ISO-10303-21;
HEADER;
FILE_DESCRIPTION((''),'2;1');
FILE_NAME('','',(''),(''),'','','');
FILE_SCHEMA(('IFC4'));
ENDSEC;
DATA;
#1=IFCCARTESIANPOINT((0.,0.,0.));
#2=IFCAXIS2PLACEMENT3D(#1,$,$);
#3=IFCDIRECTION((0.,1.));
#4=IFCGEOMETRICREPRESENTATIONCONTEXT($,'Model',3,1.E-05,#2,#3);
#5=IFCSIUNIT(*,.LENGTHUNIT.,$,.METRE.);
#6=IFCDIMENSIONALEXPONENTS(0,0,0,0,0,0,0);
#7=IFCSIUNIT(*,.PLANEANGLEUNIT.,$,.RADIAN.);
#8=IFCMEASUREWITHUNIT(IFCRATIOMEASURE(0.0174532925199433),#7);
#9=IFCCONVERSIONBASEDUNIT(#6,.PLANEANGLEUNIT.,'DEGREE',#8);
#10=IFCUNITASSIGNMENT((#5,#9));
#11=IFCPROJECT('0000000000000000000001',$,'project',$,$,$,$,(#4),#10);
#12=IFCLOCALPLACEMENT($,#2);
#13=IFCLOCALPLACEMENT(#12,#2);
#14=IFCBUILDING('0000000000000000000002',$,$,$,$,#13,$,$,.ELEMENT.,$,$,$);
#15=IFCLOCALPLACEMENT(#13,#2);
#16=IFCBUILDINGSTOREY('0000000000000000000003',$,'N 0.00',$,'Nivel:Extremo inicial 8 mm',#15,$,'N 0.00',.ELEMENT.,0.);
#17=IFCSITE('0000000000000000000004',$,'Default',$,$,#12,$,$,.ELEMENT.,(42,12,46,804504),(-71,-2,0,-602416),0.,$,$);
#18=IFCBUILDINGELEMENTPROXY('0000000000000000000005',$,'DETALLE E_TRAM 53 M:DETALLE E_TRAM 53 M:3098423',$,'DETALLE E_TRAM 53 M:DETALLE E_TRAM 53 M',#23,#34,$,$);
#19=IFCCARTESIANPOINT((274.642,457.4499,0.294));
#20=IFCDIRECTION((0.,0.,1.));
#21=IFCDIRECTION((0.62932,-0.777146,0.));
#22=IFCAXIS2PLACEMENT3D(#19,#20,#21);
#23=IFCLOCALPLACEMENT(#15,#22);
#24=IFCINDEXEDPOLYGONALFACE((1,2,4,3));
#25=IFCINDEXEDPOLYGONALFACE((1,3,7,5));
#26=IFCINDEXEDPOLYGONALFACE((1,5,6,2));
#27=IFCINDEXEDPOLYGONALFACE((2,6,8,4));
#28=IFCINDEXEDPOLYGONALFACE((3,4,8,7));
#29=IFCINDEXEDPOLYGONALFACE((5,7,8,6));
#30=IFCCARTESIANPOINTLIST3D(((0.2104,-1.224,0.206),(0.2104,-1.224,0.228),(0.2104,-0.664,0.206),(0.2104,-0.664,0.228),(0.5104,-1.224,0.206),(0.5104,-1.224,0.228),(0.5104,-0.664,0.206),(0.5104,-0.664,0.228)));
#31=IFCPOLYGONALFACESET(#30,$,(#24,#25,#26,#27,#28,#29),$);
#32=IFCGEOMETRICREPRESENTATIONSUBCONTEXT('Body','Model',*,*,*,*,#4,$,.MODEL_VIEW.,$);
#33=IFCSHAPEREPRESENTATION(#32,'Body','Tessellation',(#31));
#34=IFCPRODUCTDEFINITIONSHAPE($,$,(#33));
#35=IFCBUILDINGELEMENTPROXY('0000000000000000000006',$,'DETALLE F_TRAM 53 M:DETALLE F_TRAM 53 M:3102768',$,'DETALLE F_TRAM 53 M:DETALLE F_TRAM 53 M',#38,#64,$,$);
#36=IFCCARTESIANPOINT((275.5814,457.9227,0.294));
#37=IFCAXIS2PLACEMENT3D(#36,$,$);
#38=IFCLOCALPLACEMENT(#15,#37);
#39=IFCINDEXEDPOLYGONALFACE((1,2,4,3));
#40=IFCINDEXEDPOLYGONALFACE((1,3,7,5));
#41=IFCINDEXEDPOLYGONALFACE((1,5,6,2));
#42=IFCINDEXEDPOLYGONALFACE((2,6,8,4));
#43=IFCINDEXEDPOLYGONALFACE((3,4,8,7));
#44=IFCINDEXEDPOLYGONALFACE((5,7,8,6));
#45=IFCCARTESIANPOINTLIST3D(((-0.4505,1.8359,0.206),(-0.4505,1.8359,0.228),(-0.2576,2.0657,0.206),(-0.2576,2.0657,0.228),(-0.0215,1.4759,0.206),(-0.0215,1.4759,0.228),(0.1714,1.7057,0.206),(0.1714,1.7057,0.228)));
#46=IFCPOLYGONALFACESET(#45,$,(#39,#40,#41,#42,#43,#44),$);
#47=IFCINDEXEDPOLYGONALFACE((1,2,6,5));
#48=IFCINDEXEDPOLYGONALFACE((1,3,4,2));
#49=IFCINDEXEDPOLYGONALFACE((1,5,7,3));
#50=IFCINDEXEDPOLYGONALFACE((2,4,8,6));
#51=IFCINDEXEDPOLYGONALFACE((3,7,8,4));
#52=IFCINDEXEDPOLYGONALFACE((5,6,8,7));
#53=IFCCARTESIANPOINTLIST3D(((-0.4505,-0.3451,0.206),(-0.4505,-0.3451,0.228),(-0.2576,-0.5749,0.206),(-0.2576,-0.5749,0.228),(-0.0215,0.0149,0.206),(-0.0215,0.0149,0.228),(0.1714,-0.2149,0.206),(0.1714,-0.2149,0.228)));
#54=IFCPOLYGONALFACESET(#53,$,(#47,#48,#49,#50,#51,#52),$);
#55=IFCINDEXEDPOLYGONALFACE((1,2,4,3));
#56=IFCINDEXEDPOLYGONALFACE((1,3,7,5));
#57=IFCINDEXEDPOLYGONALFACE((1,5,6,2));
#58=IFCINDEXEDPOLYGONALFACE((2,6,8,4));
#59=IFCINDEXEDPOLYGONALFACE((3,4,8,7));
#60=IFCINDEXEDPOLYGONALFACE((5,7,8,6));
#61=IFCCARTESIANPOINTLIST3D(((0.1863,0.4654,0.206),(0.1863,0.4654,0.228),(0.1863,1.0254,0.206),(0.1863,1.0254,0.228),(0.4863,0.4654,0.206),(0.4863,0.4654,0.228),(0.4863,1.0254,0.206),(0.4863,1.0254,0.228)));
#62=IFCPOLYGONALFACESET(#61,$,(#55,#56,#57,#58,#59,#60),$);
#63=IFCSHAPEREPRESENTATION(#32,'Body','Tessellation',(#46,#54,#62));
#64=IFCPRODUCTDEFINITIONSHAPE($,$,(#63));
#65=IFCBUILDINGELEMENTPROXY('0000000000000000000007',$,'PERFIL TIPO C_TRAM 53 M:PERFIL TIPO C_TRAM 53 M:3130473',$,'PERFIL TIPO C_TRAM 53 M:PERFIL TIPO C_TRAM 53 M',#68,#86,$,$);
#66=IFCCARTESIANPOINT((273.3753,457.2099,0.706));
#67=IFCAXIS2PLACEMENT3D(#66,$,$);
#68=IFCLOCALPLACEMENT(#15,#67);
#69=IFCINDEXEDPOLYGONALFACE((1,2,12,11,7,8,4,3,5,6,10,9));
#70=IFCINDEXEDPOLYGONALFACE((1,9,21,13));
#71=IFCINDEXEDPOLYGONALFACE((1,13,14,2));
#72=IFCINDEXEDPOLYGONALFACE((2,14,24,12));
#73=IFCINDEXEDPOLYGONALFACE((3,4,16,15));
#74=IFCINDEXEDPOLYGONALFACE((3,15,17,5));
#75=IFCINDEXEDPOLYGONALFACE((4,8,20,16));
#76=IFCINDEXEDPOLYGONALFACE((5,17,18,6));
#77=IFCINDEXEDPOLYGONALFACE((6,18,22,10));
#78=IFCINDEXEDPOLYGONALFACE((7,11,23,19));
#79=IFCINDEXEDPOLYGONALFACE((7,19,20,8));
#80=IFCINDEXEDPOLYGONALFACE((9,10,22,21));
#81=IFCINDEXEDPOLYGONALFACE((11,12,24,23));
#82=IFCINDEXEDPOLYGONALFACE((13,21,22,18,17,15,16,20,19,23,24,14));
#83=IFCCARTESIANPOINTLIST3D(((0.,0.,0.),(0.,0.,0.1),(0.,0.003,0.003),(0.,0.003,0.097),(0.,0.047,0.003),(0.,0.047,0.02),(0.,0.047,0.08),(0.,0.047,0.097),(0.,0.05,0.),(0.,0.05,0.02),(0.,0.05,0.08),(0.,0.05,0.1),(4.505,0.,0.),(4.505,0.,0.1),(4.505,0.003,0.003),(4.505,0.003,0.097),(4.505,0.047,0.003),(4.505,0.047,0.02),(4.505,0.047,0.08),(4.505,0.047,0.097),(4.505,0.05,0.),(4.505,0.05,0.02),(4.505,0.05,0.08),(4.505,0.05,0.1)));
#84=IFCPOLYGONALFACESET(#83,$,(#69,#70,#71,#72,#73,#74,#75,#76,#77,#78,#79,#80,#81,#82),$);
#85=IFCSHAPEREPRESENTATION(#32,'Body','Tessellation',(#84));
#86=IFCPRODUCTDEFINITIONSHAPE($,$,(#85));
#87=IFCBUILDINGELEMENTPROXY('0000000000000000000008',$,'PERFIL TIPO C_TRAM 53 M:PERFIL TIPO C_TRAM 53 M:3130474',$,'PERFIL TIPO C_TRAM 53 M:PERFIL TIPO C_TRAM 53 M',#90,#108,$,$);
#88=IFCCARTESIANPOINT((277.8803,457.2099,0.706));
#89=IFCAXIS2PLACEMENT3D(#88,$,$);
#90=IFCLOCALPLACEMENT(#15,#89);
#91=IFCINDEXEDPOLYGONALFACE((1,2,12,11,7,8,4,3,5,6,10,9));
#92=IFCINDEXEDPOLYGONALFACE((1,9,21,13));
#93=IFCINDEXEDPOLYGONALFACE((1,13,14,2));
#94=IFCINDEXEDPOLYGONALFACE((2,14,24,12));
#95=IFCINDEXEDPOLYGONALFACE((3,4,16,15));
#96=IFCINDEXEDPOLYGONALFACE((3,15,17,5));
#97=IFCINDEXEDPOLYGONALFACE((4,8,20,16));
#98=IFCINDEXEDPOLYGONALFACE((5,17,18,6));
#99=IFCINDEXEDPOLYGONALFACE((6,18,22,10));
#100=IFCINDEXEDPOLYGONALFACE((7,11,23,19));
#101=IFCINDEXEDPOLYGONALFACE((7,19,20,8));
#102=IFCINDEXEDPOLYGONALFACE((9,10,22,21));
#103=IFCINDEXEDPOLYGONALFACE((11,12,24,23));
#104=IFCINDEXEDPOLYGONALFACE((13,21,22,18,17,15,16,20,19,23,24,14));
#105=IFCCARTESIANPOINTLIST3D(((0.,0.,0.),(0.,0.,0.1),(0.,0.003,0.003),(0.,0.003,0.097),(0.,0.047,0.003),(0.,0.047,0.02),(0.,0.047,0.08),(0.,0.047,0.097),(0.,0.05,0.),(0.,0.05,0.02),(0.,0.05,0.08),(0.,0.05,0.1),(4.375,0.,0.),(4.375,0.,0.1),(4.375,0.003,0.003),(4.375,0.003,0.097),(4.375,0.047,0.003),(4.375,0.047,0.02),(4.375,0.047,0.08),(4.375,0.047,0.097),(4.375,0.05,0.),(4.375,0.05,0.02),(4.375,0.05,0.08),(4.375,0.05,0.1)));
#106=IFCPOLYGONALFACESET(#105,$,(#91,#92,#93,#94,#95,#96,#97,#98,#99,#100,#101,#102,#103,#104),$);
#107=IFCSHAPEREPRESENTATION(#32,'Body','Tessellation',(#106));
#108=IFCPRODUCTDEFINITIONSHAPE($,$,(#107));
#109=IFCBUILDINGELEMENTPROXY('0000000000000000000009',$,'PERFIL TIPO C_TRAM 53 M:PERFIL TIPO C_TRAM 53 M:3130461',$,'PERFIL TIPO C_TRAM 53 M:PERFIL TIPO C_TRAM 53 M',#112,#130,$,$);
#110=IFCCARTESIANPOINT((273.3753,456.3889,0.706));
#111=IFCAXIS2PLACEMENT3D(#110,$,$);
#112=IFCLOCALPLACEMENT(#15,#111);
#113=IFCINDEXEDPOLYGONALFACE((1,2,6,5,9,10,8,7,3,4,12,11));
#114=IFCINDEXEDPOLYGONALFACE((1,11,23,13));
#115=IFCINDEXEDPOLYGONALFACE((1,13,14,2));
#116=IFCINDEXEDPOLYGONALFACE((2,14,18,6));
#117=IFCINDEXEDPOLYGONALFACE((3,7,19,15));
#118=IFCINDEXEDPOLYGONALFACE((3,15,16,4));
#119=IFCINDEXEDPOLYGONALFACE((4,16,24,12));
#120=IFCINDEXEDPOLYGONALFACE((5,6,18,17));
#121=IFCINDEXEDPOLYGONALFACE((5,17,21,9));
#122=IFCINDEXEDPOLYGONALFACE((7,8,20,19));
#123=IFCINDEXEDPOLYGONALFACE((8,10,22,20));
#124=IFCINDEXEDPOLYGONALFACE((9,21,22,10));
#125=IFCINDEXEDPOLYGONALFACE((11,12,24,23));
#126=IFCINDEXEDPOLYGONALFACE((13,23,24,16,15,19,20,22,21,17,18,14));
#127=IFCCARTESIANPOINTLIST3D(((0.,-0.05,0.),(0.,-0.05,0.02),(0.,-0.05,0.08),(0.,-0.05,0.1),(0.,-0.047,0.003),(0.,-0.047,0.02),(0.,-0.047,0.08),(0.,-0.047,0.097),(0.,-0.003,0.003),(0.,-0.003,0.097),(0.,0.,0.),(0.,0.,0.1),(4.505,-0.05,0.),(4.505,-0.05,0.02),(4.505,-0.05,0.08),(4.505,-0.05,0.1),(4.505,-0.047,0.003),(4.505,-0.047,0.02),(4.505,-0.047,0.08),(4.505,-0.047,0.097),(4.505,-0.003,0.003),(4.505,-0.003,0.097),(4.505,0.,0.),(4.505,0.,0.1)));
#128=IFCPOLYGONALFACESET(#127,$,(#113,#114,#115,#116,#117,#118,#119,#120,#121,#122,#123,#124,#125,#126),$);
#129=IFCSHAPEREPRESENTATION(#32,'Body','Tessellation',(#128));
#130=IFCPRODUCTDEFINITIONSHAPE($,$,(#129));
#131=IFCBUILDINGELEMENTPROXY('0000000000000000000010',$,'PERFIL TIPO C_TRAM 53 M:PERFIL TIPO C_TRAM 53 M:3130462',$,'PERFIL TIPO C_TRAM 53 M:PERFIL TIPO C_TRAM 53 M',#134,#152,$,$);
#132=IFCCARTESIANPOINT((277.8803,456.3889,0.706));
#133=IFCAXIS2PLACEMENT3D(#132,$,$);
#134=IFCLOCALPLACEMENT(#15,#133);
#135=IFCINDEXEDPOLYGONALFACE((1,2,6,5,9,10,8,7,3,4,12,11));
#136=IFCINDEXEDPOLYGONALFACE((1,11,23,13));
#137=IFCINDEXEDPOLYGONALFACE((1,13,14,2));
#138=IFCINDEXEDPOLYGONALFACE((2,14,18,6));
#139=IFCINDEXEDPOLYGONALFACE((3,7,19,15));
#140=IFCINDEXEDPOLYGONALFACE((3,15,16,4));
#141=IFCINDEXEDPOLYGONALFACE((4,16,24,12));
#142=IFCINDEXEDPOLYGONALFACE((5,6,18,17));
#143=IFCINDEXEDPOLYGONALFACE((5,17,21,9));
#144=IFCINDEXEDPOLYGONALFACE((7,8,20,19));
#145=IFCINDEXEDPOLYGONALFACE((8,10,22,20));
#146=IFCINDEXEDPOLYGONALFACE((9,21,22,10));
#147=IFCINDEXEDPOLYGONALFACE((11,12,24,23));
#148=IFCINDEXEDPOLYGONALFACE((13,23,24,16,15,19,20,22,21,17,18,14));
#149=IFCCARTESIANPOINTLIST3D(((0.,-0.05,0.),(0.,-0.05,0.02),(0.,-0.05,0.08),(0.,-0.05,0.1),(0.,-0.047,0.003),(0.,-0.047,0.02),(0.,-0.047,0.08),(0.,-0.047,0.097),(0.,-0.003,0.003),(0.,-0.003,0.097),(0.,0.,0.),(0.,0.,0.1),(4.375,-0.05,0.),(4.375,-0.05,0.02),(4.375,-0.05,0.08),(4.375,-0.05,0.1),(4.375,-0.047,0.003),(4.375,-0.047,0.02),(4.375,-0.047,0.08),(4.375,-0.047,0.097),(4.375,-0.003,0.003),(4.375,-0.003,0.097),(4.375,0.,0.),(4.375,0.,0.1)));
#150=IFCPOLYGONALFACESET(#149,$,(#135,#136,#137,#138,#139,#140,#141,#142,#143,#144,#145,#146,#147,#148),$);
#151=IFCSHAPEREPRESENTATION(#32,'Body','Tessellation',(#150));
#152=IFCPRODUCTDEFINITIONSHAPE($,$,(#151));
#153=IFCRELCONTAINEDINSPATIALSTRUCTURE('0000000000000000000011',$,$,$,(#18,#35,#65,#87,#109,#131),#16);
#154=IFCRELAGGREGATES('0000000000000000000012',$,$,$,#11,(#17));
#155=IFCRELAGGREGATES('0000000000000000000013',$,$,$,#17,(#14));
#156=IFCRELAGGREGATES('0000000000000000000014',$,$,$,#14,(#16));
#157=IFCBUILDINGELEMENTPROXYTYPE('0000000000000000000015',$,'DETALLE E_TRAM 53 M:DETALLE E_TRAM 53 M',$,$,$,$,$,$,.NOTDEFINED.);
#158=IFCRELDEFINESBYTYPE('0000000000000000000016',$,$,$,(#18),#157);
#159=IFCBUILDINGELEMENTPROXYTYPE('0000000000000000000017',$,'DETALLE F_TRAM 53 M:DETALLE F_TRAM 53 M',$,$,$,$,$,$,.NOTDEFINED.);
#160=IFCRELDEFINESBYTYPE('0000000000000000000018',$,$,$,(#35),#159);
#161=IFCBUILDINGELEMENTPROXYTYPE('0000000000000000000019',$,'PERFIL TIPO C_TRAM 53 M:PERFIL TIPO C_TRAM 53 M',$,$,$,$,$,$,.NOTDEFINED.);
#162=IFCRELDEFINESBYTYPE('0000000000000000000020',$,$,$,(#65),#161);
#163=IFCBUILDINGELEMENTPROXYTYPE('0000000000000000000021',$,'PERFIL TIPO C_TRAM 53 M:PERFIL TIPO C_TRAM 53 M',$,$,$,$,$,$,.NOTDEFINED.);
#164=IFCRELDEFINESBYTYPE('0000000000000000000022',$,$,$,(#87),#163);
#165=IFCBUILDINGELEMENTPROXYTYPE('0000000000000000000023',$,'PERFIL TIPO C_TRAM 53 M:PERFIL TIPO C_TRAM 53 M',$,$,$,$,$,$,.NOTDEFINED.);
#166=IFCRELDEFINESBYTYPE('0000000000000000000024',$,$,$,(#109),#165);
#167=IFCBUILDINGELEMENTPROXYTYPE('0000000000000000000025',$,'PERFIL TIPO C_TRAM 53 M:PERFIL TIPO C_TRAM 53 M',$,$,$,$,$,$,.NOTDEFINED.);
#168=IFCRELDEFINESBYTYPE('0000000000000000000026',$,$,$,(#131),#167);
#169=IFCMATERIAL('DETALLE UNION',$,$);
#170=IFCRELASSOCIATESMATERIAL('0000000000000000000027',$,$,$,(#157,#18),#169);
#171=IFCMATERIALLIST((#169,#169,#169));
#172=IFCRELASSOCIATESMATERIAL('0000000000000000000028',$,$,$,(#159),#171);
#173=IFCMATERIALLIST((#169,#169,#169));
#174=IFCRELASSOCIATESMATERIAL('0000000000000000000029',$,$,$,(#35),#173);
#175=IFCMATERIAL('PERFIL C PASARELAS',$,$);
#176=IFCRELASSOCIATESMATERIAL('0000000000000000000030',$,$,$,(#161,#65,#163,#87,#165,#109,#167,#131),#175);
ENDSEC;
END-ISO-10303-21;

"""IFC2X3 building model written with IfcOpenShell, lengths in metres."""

from ifc_helpers import new_model, entity, si_unit, converted_unit, direction, frame, frame_2d, origin, place, context, subcontext, project, spatial, polyline, rectangle, outline, extrude, source, transform, mapped, material, material_list, type_object, type_shapes, element, save


model = new_model("IFC2X3")

# Units and contexts
model_context = context("Model", 3, precision=1e-05, world=origin(), true_north=direction((0.0, 1.0)))
body_context = subcontext(model_context, "Body", "Model", "MODEL_VIEW")
ifc_project = project(units=[si_unit("LENGTHUNIT", "METRE"), converted_unit("PLANEANGLEUNIT", "DEGREE", entity("IfcRatioMeasure", 0.0174532925199433), si_unit("PLANEANGLEUNIT", "RADIAN"), dimensions=[0, 0, 0, 0, 0, 0, 0])], contexts=[model_context])

# Site, building, storey
site_placement = place(None, origin())
site = spatial("IfcSite", under=ifc_project, at=site_placement, Name="Default", CompositionType="ELEMENT", RefLatitude=(42, 12, 46, 804504), RefLongitude=(-71, -2, 0, -602416), RefElevation=0.0)
building_placement = place(site_placement, origin())
building = spatial("IfcBuilding", under=site, at=building_placement, CompositionType="ELEMENT")
storey_placement = place(building_placement, origin())
storey = spatial("IfcBuildingStorey", under=building, at=storey_placement, Name="N 0.00", ObjectType="Nivel:Extremo inicial 8 mm", LongName="N 0.00", CompositionType="ELEMENT", Elevation=0.0)

# Building element proxies
ifc_material_1 = material(Name="DETALLE UNION")
building_element_proxy_type_1 = type_object("IfcBuildingElementProxyType", Name="DETALLE E_TRAM 53 M:DETALLE E_TRAM 53 M", PredefinedType="NOTDEFINED", material=ifc_material_1)
shared_shape_1 = source(origin(), body_context, "Body", "SweptSolid", [
    extrude(rectangle(XDim=0.3, YDim=0.56, at=frame_2d((0.0, 0.0), x_axis=(1.0, 0.0))), frame((0.3604, -0.944, 0.206), z_axis=(0.0, 0.0, 1.0), x_axis=(-1.0, 0.0, 0.0)), (0.0, 0.0, 1.0), 0.022),
])
type_shapes(building_element_proxy_type_1, [shared_shape_1])
proxy_1_placement = place(storey_placement, frame((274.642, 457.4499, 0.294), z_axis=(0.0, 0.0, 1.0), x_axis=(0.62932, -0.777146, 0.0)))
element("IfcBuildingElementProxy", 1, at=proxy_1_placement, inside=storey, type_object=building_element_proxy_type_1, material=ifc_material_1, Name="DETALLE E_TRAM 53 M:DETALLE E_TRAM 53 M:3098423", ObjectType="DETALLE E_TRAM 53 M:DETALLE E_TRAM 53 M", context=body_context, shape_type="MappedRepresentation", body=[
    mapped(shared_shape_1, transform((0.0, 0.0, 0.0), scale=1.0)),
])
ifc_material_list_1 = material_list([ifc_material_1, ifc_material_1, ifc_material_1])
ifc_material_list_2 = material_list([ifc_material_1, ifc_material_1, ifc_material_1])
building_element_proxy_type_2 = type_object("IfcBuildingElementProxyType", Name="DETALLE F_TRAM 53 M:DETALLE F_TRAM 53 M", PredefinedType="NOTDEFINED", material=ifc_material_list_2)
shared_shape_2 = source(origin(), body_context, "Body", "SweptSolid", [
    extrude(rectangle(XDim=0.3, YDim=0.56, at=frame_2d((0.0, 0.0), x_axis=(1.0, 0.0))), frame((-0.1396, 1.7708, 0.206), z_axis=(0.0, 0.0, 1.0), x_axis=(-0.642788, -0.766044, 0.0)), (0.0, 0.0, 1.0), 0.022),
    extrude(rectangle(XDim=0.56, YDim=0.3, at=frame_2d((0.0, 0.0), x_axis=(1.0, 0.0))), frame((-0.1396, -0.28, 0.206), z_axis=(0.0, 0.0, 1.0), x_axis=(0.766044, 0.642788, 0.0)), (0.0, 0.0, 1.0), 0.022),
    extrude(rectangle(XDim=0.56, YDim=0.3, at=frame_2d((0.0, 0.0), x_axis=(1.0, 0.0))), frame((0.3363, 0.7454, 0.206), z_axis=(0.0, 0.0, 1.0), x_axis=(0.0, 1.0, 0.0)), (0.0, 0.0, 1.0), 0.022),
])
type_shapes(building_element_proxy_type_2, [shared_shape_2])
proxy_2_placement = place(storey_placement, frame((275.5814, 457.9227, 0.294)))
element("IfcBuildingElementProxy", 2, at=proxy_2_placement, inside=storey, type_object=building_element_proxy_type_2, material=ifc_material_list_1, Name="DETALLE F_TRAM 53 M:DETALLE F_TRAM 53 M:3102768", ObjectType="DETALLE F_TRAM 53 M:DETALLE F_TRAM 53 M", context=body_context, shape_type="MappedRepresentation", body=[
    mapped(shared_shape_2, transform((0.0, 0.0, 0.0), scale=1.0)),
])
ifc_material_2 = material(Name="PERFIL C PASARELAS")
building_element_proxy_type_3 = type_object("IfcBuildingElementProxyType", Name="PERFIL TIPO C_TRAM 53 M:PERFIL TIPO C_TRAM 53 M", PredefinedType="NOTDEFINED", material=ifc_material_2)
shared_shape_3 = source(origin(), body_context, "Body", "SweptSolid", [
    extrude(outline(polyline([(-0.0172, 0.03), (-0.0142, 0.03), (-0.0142, 0.047), (0.0298, 0.047), (0.0298, -0.047), (-0.0142, -0.047), (-0.0142, -0.03), (-0.0172, -0.03), (-0.0172, -0.05), (0.0328, -0.05), (0.0328, 0.05), (-0.0172, 0.05), (-0.0172, 0.03)])), frame((0.0, 0.0328, 0.05), z_axis=(1.0, 0.0, 0.0), x_axis=(0.0, -1.0, 0.0)), (0.0, 0.0, 1.0), 4.505),
])
type_shapes(building_element_proxy_type_3, [shared_shape_3])
proxy_3_placement = place(storey_placement, frame((273.3753, 457.2099, 0.706)))
element("IfcBuildingElementProxy", 3, at=proxy_3_placement, inside=storey, type_object=building_element_proxy_type_3, material=ifc_material_2, Name="PERFIL TIPO C_TRAM 53 M:PERFIL TIPO C_TRAM 53 M:3130473", ObjectType="PERFIL TIPO C_TRAM 53 M:PERFIL TIPO C_TRAM 53 M", context=body_context, shape_type="MappedRepresentation", body=[
    mapped(shared_shape_3, transform((0.0, 0.0, 0.0), scale=1.0)),
])
building_element_proxy_type_4 = type_object("IfcBuildingElementProxyType", Name="PERFIL TIPO C_TRAM 53 M:PERFIL TIPO C_TRAM 53 M", PredefinedType="NOTDEFINED", material=ifc_material_2)
shared_shape_4 = source(origin(), body_context, "Body", "SweptSolid", [
    extrude(outline(polyline([(-0.0172, 0.03), (-0.0142, 0.03), (-0.0142, 0.047), (0.0298, 0.047), (0.0298, -0.047), (-0.0142, -0.047), (-0.0142, -0.03), (-0.0172, -0.03), (-0.0172, -0.05), (0.0328, -0.05), (0.0328, 0.05), (-0.0172, 0.05), (-0.0172, 0.03)])), frame((0.0, 0.0328, 0.05), z_axis=(1.0, 0.0, 0.0), x_axis=(0.0, -1.0, 0.0)), (0.0, 0.0, 1.0), 4.375),
])
type_shapes(building_element_proxy_type_4, [shared_shape_4])
proxy_4_placement = place(storey_placement, frame((277.8803, 457.2099, 0.706)))
element("IfcBuildingElementProxy", 4, at=proxy_4_placement, inside=storey, type_object=building_element_proxy_type_4, material=ifc_material_2, Name="PERFIL TIPO C_TRAM 53 M:PERFIL TIPO C_TRAM 53 M:3130474", ObjectType="PERFIL TIPO C_TRAM 53 M:PERFIL TIPO C_TRAM 53 M", context=body_context, shape_type="MappedRepresentation", body=[
    mapped(shared_shape_4, transform((0.0, 0.0, 0.0), scale=1.0)),
])
building_element_proxy_type_5 = type_object("IfcBuildingElementProxyType", Name="PERFIL TIPO C_TRAM 53 M:PERFIL TIPO C_TRAM 53 M", PredefinedType="NOTDEFINED", material=ifc_material_2)
shared_shape_5 = source(origin(), body_context, "Body", "SweptSolid", [
    extrude(outline(polyline([(0.03, -0.0172), (0.05, -0.0172), (0.05, 0.0328), (-0.05, 0.0328), (-0.05, -0.0172), (-0.03, -0.0172), (-0.03, -0.0142), (-0.047, -0.0142), (-0.047, 0.0298), (0.047, 0.0298), (0.047, -0.0142), (0.03, -0.0142), (0.03, -0.0172)])), frame((0.0, -0.0328, 0.05), z_axis=(1.0, 0.0, 0.0), x_axis=(0.0, 0.0, -1.0)), (0.0, 0.0, 1.0), 4.505),
])
type_shapes(building_element_proxy_type_5, [shared_shape_5])
proxy_5_placement = place(storey_placement, frame((273.3753, 456.3889, 0.706)))
element("IfcBuildingElementProxy", 5, at=proxy_5_placement, inside=storey, type_object=building_element_proxy_type_5, material=ifc_material_2, Name="PERFIL TIPO C_TRAM 53 M:PERFIL TIPO C_TRAM 53 M:3130461", ObjectType="PERFIL TIPO C_TRAM 53 M:PERFIL TIPO C_TRAM 53 M", context=body_context, shape_type="MappedRepresentation", body=[
    mapped(shared_shape_5, transform((0.0, 0.0, 0.0), scale=1.0)),
])
building_element_proxy_type_6 = type_object("IfcBuildingElementProxyType", Name="PERFIL TIPO C_TRAM 53 M:PERFIL TIPO C_TRAM 53 M", PredefinedType="NOTDEFINED", material=ifc_material_2)
shared_shape_6 = source(origin(), body_context, "Body", "SweptSolid", [
    extrude(outline(polyline([(0.03, -0.0172), (0.05, -0.0172), (0.05, 0.0328), (-0.05, 0.0328), (-0.05, -0.0172), (-0.03, -0.0172), (-0.03, -0.0142), (-0.047, -0.0142), (-0.047, 0.0298), (0.047, 0.0298), (0.047, -0.0142), (0.03, -0.0142), (0.03, -0.0172)])), frame((0.0, -0.0328, 0.05), z_axis=(1.0, 0.0, 0.0), x_axis=(0.0, 0.0, -1.0)), (0.0, 0.0, 1.0), 4.375),
])
type_shapes(building_element_proxy_type_6, [shared_shape_6])
proxy_6_placement = place(storey_placement, frame((277.8803, 456.3889, 0.706)))
element("IfcBuildingElementProxy", 6, at=proxy_6_placement, inside=storey, type_object=building_element_proxy_type_6, material=ifc_material_2, Name="PERFIL TIPO C_TRAM 53 M:PERFIL TIPO C_TRAM 53 M:3130462", ObjectType="PERFIL TIPO C_TRAM 53 M:PERFIL TIPO C_TRAM 53 M", context=body_context, shape_type="MappedRepresentation", body=[
    mapped(shared_shape_6, transform((0.0, 0.0, 0.0), scale=1.0)),
])

save(model, "model.ifc")
